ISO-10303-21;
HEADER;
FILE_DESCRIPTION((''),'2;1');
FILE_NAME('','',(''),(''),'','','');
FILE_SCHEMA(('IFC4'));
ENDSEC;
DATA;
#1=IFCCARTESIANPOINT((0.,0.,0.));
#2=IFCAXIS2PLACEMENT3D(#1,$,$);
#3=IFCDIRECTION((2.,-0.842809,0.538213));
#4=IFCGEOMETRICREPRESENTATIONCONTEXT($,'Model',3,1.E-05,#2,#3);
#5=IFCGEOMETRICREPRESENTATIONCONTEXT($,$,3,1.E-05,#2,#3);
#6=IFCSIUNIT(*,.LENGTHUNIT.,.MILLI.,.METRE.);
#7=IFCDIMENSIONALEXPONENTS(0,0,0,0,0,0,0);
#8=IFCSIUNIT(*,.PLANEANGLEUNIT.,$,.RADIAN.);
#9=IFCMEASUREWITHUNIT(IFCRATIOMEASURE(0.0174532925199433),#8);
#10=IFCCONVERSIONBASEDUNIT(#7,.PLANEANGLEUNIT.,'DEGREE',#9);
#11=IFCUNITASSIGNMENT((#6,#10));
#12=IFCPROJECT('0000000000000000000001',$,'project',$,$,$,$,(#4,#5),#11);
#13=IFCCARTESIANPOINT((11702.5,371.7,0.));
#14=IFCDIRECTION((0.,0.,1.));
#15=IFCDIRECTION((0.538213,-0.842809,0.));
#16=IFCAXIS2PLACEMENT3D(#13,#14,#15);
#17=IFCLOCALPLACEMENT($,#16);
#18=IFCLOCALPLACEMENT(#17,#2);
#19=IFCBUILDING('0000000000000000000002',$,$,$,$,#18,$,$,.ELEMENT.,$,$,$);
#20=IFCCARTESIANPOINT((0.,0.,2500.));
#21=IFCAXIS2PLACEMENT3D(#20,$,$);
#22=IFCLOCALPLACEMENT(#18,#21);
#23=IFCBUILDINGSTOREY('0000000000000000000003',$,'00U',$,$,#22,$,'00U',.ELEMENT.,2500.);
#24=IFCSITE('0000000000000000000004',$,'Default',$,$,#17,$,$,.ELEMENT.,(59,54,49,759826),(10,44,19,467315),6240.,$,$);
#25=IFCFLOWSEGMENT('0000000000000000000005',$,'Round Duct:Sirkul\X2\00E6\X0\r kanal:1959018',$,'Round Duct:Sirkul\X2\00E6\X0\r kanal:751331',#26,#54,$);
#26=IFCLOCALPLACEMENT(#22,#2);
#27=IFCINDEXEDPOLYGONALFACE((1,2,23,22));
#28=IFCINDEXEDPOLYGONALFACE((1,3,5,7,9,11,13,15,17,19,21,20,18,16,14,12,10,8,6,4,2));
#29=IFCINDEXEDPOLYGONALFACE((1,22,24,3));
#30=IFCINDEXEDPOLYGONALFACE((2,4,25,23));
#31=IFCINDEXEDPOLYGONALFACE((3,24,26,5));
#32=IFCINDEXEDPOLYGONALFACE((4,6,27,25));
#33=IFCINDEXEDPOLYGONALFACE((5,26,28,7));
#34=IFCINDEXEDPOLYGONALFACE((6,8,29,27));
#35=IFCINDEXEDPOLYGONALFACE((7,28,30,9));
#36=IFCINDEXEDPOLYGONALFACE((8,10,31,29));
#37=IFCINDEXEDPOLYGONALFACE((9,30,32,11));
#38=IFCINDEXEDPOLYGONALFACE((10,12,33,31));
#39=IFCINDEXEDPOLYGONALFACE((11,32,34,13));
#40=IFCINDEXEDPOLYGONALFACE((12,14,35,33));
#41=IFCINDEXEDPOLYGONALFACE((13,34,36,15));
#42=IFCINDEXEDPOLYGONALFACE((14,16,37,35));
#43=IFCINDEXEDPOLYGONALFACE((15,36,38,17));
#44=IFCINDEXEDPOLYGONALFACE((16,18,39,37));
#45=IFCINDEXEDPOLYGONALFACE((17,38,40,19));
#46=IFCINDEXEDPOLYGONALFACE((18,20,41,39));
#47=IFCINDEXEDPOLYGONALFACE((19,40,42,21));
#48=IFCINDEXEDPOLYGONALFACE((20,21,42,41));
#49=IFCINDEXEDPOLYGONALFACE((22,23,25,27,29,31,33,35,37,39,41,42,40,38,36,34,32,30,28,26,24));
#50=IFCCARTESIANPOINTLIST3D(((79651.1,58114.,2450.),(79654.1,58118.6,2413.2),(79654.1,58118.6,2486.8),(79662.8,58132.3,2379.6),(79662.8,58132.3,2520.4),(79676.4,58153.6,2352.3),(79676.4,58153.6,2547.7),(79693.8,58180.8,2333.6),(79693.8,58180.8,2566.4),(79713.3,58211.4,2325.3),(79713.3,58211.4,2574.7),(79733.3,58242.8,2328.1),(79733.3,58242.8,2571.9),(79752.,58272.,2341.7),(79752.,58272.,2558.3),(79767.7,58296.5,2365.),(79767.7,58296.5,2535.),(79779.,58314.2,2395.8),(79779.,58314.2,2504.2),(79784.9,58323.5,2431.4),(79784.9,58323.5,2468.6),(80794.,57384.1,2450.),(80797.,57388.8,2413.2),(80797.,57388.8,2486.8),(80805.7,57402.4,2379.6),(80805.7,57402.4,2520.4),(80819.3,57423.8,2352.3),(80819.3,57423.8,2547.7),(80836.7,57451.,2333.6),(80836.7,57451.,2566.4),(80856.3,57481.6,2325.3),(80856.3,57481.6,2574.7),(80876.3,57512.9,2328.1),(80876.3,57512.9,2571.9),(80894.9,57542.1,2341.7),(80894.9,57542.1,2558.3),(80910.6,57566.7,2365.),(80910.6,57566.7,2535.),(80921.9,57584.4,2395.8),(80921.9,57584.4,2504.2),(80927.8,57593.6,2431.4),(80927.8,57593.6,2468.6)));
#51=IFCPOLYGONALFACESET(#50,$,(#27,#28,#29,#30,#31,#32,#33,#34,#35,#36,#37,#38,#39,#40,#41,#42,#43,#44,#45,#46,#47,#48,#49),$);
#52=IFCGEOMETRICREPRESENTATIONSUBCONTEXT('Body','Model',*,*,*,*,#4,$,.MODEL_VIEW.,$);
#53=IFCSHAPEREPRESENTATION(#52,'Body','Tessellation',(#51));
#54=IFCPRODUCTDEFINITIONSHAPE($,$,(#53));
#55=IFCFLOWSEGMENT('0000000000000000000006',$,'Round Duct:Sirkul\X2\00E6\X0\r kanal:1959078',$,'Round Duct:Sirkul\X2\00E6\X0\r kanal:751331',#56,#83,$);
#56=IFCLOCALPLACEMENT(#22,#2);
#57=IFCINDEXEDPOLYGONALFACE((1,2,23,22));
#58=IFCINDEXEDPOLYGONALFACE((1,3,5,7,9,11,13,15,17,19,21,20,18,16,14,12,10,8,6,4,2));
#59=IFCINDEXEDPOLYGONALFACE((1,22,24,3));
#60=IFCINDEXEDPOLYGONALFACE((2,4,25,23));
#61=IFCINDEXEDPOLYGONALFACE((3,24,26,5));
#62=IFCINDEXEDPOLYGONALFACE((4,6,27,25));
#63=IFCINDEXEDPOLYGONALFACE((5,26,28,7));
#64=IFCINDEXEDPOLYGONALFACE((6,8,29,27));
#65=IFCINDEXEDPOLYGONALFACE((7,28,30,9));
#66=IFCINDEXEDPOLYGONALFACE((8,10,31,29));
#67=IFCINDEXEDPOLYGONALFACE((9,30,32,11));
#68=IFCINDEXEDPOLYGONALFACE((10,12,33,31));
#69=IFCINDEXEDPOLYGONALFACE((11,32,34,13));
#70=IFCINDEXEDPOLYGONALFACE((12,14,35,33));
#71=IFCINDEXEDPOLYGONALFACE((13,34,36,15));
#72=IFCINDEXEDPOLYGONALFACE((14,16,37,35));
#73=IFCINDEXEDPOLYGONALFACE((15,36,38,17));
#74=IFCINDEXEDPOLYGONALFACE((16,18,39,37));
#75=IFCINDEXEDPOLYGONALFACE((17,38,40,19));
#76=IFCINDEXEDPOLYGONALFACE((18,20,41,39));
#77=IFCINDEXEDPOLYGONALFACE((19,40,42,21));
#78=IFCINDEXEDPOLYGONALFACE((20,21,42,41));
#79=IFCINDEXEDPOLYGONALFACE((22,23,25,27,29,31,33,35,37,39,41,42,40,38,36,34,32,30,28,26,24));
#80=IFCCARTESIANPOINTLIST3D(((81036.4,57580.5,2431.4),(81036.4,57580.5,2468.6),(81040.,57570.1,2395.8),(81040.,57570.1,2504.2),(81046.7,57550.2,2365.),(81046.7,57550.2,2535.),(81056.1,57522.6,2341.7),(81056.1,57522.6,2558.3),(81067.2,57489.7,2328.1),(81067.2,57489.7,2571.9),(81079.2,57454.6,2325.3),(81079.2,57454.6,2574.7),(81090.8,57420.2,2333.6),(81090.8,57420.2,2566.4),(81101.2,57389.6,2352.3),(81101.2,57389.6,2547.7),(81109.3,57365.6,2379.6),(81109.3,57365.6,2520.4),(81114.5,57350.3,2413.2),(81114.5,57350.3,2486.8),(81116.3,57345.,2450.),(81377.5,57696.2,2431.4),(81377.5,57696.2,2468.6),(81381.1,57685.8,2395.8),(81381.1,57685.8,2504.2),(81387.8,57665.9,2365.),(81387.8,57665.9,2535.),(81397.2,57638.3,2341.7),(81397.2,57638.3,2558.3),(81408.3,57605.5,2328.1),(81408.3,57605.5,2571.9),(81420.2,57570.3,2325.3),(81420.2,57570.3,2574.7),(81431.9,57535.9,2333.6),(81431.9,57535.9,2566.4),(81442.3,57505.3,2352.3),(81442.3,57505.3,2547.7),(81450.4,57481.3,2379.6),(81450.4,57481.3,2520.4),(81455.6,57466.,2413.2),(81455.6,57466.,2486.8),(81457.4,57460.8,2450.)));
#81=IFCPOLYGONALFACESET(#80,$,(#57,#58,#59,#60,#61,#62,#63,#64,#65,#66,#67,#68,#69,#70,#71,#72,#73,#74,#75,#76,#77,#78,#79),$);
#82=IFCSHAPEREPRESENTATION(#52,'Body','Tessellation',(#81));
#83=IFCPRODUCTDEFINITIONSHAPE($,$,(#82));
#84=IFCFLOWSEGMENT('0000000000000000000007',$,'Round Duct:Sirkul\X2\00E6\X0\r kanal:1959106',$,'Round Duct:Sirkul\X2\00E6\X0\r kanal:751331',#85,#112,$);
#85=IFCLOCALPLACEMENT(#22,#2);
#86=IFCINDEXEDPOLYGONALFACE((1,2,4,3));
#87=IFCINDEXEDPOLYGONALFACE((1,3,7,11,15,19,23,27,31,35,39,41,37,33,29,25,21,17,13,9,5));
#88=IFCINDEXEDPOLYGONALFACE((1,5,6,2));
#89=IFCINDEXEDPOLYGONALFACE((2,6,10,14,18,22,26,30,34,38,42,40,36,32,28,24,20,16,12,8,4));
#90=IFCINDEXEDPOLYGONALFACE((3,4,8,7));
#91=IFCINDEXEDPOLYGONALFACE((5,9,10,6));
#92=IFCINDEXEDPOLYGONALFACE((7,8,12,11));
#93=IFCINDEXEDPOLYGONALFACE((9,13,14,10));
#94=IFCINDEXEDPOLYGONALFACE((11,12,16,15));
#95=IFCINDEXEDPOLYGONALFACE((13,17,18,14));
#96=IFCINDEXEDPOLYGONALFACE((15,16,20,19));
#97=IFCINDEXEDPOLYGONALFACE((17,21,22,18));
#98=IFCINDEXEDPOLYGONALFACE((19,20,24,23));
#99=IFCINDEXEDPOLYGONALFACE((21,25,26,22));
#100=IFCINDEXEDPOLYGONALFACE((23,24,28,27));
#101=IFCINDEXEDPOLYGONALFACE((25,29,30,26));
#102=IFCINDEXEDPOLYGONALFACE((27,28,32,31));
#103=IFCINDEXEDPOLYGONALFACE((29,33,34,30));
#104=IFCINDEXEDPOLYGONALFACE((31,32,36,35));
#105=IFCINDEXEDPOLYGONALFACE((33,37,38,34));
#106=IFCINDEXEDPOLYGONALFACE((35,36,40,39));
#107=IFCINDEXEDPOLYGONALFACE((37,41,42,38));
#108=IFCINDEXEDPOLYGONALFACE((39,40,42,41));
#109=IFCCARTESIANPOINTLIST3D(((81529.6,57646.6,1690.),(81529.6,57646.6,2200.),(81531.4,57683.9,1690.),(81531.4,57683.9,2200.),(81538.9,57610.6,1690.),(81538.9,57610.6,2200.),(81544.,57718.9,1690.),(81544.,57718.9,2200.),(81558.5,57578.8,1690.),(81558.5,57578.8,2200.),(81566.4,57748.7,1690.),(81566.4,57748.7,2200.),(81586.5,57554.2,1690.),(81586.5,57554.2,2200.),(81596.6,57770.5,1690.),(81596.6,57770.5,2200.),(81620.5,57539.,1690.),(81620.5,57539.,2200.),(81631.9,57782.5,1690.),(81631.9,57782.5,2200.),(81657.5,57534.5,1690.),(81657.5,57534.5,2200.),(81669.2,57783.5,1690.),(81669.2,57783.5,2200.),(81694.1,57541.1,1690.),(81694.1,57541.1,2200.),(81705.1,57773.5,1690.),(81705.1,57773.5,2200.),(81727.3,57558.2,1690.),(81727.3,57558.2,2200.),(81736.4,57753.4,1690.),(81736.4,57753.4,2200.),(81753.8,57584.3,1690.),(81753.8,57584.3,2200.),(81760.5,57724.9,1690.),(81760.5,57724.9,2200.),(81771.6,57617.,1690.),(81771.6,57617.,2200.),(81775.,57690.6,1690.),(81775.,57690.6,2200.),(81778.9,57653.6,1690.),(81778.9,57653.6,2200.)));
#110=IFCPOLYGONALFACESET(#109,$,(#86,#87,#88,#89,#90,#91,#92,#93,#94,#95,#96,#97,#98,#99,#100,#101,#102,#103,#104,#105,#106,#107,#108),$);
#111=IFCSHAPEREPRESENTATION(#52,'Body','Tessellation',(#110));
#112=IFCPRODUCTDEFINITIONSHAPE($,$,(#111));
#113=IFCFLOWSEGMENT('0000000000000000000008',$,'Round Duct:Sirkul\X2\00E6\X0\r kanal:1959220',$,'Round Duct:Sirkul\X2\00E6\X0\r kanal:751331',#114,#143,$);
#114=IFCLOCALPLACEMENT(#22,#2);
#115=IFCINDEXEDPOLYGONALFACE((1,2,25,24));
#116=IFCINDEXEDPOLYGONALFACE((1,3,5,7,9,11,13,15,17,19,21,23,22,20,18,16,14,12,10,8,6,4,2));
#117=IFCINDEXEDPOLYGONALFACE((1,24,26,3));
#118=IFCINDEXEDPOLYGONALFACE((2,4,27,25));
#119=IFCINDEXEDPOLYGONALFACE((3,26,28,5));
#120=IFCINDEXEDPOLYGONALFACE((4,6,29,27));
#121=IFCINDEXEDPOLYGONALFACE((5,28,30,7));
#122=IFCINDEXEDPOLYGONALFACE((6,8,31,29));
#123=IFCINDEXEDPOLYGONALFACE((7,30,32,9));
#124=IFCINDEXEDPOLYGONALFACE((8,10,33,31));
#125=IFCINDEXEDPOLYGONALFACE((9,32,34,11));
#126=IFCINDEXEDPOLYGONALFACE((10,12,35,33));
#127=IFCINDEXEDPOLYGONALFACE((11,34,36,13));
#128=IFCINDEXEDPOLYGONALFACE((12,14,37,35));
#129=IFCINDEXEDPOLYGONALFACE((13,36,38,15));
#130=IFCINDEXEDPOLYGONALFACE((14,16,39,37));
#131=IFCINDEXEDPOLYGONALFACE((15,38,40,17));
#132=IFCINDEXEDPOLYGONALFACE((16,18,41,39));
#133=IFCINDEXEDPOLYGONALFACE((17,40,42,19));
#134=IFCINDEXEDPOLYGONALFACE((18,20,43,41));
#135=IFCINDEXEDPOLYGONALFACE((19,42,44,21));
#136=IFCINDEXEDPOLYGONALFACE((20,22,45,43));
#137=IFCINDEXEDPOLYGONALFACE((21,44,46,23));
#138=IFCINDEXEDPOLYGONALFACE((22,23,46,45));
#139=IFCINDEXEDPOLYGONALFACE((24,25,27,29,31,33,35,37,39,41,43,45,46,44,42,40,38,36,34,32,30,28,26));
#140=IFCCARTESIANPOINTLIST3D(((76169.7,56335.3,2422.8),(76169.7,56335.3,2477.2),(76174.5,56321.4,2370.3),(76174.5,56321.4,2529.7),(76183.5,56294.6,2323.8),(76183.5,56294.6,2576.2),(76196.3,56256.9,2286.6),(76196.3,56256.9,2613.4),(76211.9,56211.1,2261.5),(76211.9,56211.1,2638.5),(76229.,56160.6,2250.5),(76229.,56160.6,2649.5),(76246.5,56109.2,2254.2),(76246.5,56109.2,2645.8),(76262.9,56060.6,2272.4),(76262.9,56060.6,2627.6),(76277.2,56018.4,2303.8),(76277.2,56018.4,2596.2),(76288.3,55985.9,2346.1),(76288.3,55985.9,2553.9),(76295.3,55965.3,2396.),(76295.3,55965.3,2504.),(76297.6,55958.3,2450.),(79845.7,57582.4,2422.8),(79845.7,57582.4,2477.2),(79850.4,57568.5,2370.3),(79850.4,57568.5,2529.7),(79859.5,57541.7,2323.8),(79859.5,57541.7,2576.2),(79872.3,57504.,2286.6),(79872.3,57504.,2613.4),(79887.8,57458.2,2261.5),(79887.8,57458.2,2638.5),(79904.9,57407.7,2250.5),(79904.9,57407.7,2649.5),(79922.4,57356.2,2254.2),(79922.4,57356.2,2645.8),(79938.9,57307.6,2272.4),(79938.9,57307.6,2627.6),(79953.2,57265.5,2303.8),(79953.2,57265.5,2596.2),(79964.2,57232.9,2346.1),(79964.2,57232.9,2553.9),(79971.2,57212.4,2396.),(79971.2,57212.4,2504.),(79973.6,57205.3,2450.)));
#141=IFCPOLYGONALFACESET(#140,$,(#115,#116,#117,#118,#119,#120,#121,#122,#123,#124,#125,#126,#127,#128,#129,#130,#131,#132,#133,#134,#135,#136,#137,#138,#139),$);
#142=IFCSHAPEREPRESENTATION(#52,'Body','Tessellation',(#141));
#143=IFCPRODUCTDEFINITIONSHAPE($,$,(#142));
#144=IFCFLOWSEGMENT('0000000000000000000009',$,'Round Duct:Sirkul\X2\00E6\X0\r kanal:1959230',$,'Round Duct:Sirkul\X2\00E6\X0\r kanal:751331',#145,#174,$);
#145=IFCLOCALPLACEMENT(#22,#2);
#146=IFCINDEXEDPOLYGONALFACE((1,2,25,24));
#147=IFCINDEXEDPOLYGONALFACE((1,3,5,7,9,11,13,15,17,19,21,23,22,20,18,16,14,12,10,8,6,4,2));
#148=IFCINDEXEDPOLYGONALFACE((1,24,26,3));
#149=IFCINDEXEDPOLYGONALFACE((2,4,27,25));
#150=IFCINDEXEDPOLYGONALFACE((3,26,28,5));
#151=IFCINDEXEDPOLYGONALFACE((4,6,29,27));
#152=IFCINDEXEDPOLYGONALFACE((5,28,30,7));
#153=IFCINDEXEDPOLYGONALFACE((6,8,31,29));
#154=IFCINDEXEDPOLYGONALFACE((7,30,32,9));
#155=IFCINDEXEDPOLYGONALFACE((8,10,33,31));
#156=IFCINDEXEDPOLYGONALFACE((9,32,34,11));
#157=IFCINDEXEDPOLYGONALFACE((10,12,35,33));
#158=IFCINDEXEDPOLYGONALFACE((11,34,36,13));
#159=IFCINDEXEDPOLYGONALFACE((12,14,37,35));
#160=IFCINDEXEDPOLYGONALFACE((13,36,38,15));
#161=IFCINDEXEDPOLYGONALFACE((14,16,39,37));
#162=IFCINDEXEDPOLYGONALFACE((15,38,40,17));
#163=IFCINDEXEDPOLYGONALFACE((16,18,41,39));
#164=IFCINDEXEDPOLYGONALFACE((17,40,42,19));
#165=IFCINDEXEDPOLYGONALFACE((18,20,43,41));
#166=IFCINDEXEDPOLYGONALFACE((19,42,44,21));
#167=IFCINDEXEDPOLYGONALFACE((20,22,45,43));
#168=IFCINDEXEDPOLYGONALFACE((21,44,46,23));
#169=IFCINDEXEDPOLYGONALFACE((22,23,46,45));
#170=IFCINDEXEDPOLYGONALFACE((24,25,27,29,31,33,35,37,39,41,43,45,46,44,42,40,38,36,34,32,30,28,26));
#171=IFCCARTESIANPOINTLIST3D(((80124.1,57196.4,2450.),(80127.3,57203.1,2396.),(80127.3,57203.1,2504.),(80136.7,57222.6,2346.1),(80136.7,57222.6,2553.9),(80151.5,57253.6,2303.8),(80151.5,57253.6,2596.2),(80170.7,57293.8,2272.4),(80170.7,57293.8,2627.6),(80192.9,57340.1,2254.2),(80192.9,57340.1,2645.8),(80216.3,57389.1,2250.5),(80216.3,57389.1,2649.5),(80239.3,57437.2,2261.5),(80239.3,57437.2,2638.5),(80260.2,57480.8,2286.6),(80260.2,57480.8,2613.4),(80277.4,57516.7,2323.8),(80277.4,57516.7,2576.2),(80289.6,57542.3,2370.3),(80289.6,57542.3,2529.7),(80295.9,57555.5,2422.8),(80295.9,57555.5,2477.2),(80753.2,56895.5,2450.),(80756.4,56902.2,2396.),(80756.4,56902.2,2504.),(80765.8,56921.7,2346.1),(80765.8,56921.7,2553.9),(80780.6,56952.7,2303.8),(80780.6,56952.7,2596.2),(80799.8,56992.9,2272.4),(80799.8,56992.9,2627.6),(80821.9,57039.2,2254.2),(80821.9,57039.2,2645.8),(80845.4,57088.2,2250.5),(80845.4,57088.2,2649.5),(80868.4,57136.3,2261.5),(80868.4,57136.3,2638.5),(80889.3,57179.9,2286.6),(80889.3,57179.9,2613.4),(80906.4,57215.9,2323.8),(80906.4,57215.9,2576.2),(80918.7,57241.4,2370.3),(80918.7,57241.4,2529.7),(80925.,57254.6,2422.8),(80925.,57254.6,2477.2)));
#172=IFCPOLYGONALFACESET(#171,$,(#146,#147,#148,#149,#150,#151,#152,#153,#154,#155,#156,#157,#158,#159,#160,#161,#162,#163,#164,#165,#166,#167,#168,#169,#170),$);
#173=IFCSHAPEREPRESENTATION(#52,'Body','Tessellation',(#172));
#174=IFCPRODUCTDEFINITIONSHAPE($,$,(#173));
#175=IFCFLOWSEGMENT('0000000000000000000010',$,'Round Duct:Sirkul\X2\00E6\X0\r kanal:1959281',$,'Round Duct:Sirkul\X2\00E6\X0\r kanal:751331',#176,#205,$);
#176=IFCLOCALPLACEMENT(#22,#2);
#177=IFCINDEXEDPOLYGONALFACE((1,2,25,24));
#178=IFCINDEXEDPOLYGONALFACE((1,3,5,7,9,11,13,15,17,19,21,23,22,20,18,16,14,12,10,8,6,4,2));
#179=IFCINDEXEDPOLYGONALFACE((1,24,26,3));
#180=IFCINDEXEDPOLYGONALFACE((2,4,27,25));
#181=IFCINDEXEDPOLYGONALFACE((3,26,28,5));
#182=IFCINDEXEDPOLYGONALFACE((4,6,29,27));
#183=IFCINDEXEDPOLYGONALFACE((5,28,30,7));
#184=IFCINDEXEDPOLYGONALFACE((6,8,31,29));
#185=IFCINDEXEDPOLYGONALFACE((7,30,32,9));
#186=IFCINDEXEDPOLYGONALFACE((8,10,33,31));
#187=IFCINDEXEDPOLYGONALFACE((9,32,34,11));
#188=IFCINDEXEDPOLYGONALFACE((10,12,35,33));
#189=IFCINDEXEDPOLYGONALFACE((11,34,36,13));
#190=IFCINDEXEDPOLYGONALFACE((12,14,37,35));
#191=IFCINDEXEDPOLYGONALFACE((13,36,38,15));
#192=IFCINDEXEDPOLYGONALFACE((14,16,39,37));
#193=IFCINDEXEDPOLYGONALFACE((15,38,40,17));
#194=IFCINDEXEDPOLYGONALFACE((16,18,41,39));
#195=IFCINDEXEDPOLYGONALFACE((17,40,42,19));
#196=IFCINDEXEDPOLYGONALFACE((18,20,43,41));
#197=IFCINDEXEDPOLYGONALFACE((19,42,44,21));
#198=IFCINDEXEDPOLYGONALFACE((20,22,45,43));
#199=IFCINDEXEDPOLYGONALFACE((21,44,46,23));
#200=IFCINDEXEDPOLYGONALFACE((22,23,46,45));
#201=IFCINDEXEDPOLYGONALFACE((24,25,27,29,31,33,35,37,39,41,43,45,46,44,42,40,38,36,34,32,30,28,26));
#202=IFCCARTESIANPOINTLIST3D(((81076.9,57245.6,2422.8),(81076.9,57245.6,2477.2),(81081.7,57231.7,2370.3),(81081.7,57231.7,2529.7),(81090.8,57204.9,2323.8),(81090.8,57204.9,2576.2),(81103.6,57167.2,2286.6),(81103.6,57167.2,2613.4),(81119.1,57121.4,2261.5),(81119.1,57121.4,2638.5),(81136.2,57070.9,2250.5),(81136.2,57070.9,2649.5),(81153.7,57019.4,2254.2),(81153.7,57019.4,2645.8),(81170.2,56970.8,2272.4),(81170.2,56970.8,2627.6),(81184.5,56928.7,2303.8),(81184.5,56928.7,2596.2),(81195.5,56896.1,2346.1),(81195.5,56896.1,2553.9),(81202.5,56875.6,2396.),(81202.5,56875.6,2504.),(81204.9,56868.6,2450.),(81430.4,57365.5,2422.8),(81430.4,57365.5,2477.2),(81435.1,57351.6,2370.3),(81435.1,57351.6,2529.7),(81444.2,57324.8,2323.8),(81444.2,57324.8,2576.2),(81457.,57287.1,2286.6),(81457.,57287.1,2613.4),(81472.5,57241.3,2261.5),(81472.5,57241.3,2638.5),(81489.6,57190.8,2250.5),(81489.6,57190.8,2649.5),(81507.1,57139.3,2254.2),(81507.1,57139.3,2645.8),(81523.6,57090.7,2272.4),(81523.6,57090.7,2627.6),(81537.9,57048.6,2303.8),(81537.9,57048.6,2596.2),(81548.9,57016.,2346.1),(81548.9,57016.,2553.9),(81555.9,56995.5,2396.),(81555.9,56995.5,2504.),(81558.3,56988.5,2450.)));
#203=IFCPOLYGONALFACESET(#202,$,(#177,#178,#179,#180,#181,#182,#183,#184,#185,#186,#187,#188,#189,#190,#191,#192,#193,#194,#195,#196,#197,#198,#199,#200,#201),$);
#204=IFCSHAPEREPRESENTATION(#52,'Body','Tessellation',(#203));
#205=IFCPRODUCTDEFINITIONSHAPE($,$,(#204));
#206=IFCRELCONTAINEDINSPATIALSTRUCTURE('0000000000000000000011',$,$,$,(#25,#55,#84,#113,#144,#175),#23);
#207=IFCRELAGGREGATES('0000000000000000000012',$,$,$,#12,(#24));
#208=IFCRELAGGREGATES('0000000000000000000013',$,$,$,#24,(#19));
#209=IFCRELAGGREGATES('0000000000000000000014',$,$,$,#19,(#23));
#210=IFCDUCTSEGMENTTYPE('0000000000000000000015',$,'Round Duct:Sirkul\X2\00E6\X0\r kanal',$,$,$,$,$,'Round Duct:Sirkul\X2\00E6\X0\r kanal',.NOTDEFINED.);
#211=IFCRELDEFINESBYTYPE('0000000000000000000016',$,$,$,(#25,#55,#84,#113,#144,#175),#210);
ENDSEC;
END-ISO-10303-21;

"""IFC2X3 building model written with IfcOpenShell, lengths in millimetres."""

from ifc_helpers import new_model, entity, si_unit, converted_unit, direction, frame, origin, origin_2d_with_axis, place, context, subcontext, project, spatial, circle, extrude, type_object, element, save


model = new_model("IFC2X3")

# Units and contexts
model_context = context("Model", 3, precision=1e-05, world=origin(), true_north=direction((2.0, -0.842809, 0.538213)))
context_of_model = context(None, 3, precision=1e-05, world=origin(), true_north=direction((2.0, -0.842809, 0.538213)))
body_context = subcontext(model_context, "Body", "Model", "MODEL_VIEW")
ifc_project = project(units=[si_unit("LENGTHUNIT", "METRE", prefix="MILLI"), converted_unit("PLANEANGLEUNIT", "DEGREE", entity("IfcRatioMeasure", 0.0174532925199433), si_unit("PLANEANGLEUNIT", "RADIAN"), dimensions=[0, 0, 0, 0, 0, 0, 0])], contexts=[model_context, context_of_model])

# Site, building, storey
site_placement = place(None, frame((11702.5, 371.7, 0.0), z_axis=(0.0, 0.0, 1.0), x_axis=(0.538213, -0.842809, 0.0)))
site = spatial("IfcSite", under=ifc_project, at=site_placement, Name="Default", CompositionType="ELEMENT", RefLatitude=(59, 54, 49, 759826), RefLongitude=(10, 44, 19, 467315), RefElevation=6240.0)
building_placement = place(site_placement, origin())
building = spatial("IfcBuilding", under=site, at=building_placement, CompositionType="ELEMENT")
storey_placement = place(building_placement, frame((0.0, 0.0, 2500.0)))
storey = spatial("IfcBuildingStorey", under=building, at=storey_placement, Name="00U", LongName="00U", CompositionType="ELEMENT", Elevation=2500.0)

# Flow segments
duct_segment_type_1 = type_object("IfcDuctSegmentType", Name="Round Duct:Sirkulær kanal", ElementType="Round Duct:Sirkulær kanal", PredefinedType="NOTDEFINED")
flow_segment_1_placement = place(storey_placement, origin())
element("IfcFlowSegment", 1, at=flow_segment_1_placement, inside=storey, type_object=duct_segment_type_1, Name="Round Duct:Sirkulær kanal:1959018", ObjectType="Round Duct:Sirkulær kanal:751331", context=body_context, shape_type="SweptSolid", body=[
    extrude(circle(Radius=125.0, at=origin_2d_with_axis()), frame((80861.3, 57489.4, 2450.0), z_axis=(-0.842809, 0.538213, 0.0), x_axis=(-0.538213, -0.842809, 0.0)), (0.0, 0.0, 1.0), 1356.1),
])
flow_segment_2_placement = place(storey_placement, origin())
element("IfcFlowSegment", 2, at=flow_segment_2_placement, inside=storey, type_object=duct_segment_type_1, Name="Round Duct:Sirkulær kanal:1959078", ObjectType="Round Duct:Sirkulær kanal:751331", context=body_context, shape_type="SweptSolid", body=[
    extrude(circle(Radius=125.0, at=origin_2d_with_axis()), frame((81076.2, 57463.4, 2450.0), z_axis=(0.946982, 0.321288, 0.0), x_axis=(0.321288, -0.946982, 0.0)), (0.0, 0.0, 1.0), 360.2),
])
flow_segment_3_placement = place(storey_placement, origin())
element("IfcFlowSegment", 3, at=flow_segment_3_placement, inside=storey, type_object=duct_segment_type_1, Name="Round Duct:Sirkulær kanal:1959106", ObjectType="Round Duct:Sirkulær kanal:751331", context=body_context, shape_type="SweptSolid", body=[
    extrude(circle(Radius=125.0, at=origin_2d_with_axis()), frame((81654.0, 57659.4, 1690.0), z_axis=(0.0, 0.0, 1.0), x_axis=(0.321246, -0.946996, 0.0)), (0.0, 0.0, 1.0), 510.0),
])
flow_segment_4_placement = place(storey_placement, origin())
element("IfcFlowSegment", 4, at=flow_segment_4_placement, inside=storey, type_object=duct_segment_type_1, Name="Round Duct:Sirkulær kanal:1959220", ObjectType="Round Duct:Sirkulær kanal:751331", context=body_context, shape_type="SweptSolid", body=[
    extrude(circle(Radius=200.0, at=origin_2d_with_axis()), frame((76233.4, 56147.7, 2450.0), z_axis=(0.946991, 0.321261, 0.0), x_axis=(0.321261, -0.946991, 0.0)), (0.0, 0.0, 1.0), 3881.7),
])
flow_segment_5_placement = place(storey_placement, origin())
element("IfcFlowSegment", 5, at=flow_segment_5_placement, inside=storey, type_object=duct_segment_type_1, Name="Round Duct:Sirkulær kanal:1959230", ObjectType="Round Duct:Sirkulær kanal:751331", context=body_context, shape_type="SweptSolid", body=[
    extrude(circle(Radius=200.0, at=origin_2d_with_axis()), frame((80839.5, 57075.9, 2450.0), z_axis=(-0.902118, 0.431489, 0.0), x_axis=(-0.431489, -0.902118, 0.0)), (0.0, 0.0, 1.0), 697.3),
])
flow_segment_6_placement = place(storey_placement, origin())
element("IfcFlowSegment", 6, at=flow_segment_6_placement, inside=storey, type_object=duct_segment_type_1, Name="Round Duct:Sirkulær kanal:1959281", ObjectType="Round Duct:Sirkulær kanal:751331", context=body_context, shape_type="SweptSolid", body=[
    extrude(circle(Radius=200.0, at=origin_2d_with_axis()), frame((81140.6, 57058.0, 2450.0), z_axis=(0.946982, 0.321288, 0.0), x_axis=(0.321288, -0.946982, 0.0)), (0.0, 0.0, 1.0), 373.2),
])

save(model, "model.ifc")
